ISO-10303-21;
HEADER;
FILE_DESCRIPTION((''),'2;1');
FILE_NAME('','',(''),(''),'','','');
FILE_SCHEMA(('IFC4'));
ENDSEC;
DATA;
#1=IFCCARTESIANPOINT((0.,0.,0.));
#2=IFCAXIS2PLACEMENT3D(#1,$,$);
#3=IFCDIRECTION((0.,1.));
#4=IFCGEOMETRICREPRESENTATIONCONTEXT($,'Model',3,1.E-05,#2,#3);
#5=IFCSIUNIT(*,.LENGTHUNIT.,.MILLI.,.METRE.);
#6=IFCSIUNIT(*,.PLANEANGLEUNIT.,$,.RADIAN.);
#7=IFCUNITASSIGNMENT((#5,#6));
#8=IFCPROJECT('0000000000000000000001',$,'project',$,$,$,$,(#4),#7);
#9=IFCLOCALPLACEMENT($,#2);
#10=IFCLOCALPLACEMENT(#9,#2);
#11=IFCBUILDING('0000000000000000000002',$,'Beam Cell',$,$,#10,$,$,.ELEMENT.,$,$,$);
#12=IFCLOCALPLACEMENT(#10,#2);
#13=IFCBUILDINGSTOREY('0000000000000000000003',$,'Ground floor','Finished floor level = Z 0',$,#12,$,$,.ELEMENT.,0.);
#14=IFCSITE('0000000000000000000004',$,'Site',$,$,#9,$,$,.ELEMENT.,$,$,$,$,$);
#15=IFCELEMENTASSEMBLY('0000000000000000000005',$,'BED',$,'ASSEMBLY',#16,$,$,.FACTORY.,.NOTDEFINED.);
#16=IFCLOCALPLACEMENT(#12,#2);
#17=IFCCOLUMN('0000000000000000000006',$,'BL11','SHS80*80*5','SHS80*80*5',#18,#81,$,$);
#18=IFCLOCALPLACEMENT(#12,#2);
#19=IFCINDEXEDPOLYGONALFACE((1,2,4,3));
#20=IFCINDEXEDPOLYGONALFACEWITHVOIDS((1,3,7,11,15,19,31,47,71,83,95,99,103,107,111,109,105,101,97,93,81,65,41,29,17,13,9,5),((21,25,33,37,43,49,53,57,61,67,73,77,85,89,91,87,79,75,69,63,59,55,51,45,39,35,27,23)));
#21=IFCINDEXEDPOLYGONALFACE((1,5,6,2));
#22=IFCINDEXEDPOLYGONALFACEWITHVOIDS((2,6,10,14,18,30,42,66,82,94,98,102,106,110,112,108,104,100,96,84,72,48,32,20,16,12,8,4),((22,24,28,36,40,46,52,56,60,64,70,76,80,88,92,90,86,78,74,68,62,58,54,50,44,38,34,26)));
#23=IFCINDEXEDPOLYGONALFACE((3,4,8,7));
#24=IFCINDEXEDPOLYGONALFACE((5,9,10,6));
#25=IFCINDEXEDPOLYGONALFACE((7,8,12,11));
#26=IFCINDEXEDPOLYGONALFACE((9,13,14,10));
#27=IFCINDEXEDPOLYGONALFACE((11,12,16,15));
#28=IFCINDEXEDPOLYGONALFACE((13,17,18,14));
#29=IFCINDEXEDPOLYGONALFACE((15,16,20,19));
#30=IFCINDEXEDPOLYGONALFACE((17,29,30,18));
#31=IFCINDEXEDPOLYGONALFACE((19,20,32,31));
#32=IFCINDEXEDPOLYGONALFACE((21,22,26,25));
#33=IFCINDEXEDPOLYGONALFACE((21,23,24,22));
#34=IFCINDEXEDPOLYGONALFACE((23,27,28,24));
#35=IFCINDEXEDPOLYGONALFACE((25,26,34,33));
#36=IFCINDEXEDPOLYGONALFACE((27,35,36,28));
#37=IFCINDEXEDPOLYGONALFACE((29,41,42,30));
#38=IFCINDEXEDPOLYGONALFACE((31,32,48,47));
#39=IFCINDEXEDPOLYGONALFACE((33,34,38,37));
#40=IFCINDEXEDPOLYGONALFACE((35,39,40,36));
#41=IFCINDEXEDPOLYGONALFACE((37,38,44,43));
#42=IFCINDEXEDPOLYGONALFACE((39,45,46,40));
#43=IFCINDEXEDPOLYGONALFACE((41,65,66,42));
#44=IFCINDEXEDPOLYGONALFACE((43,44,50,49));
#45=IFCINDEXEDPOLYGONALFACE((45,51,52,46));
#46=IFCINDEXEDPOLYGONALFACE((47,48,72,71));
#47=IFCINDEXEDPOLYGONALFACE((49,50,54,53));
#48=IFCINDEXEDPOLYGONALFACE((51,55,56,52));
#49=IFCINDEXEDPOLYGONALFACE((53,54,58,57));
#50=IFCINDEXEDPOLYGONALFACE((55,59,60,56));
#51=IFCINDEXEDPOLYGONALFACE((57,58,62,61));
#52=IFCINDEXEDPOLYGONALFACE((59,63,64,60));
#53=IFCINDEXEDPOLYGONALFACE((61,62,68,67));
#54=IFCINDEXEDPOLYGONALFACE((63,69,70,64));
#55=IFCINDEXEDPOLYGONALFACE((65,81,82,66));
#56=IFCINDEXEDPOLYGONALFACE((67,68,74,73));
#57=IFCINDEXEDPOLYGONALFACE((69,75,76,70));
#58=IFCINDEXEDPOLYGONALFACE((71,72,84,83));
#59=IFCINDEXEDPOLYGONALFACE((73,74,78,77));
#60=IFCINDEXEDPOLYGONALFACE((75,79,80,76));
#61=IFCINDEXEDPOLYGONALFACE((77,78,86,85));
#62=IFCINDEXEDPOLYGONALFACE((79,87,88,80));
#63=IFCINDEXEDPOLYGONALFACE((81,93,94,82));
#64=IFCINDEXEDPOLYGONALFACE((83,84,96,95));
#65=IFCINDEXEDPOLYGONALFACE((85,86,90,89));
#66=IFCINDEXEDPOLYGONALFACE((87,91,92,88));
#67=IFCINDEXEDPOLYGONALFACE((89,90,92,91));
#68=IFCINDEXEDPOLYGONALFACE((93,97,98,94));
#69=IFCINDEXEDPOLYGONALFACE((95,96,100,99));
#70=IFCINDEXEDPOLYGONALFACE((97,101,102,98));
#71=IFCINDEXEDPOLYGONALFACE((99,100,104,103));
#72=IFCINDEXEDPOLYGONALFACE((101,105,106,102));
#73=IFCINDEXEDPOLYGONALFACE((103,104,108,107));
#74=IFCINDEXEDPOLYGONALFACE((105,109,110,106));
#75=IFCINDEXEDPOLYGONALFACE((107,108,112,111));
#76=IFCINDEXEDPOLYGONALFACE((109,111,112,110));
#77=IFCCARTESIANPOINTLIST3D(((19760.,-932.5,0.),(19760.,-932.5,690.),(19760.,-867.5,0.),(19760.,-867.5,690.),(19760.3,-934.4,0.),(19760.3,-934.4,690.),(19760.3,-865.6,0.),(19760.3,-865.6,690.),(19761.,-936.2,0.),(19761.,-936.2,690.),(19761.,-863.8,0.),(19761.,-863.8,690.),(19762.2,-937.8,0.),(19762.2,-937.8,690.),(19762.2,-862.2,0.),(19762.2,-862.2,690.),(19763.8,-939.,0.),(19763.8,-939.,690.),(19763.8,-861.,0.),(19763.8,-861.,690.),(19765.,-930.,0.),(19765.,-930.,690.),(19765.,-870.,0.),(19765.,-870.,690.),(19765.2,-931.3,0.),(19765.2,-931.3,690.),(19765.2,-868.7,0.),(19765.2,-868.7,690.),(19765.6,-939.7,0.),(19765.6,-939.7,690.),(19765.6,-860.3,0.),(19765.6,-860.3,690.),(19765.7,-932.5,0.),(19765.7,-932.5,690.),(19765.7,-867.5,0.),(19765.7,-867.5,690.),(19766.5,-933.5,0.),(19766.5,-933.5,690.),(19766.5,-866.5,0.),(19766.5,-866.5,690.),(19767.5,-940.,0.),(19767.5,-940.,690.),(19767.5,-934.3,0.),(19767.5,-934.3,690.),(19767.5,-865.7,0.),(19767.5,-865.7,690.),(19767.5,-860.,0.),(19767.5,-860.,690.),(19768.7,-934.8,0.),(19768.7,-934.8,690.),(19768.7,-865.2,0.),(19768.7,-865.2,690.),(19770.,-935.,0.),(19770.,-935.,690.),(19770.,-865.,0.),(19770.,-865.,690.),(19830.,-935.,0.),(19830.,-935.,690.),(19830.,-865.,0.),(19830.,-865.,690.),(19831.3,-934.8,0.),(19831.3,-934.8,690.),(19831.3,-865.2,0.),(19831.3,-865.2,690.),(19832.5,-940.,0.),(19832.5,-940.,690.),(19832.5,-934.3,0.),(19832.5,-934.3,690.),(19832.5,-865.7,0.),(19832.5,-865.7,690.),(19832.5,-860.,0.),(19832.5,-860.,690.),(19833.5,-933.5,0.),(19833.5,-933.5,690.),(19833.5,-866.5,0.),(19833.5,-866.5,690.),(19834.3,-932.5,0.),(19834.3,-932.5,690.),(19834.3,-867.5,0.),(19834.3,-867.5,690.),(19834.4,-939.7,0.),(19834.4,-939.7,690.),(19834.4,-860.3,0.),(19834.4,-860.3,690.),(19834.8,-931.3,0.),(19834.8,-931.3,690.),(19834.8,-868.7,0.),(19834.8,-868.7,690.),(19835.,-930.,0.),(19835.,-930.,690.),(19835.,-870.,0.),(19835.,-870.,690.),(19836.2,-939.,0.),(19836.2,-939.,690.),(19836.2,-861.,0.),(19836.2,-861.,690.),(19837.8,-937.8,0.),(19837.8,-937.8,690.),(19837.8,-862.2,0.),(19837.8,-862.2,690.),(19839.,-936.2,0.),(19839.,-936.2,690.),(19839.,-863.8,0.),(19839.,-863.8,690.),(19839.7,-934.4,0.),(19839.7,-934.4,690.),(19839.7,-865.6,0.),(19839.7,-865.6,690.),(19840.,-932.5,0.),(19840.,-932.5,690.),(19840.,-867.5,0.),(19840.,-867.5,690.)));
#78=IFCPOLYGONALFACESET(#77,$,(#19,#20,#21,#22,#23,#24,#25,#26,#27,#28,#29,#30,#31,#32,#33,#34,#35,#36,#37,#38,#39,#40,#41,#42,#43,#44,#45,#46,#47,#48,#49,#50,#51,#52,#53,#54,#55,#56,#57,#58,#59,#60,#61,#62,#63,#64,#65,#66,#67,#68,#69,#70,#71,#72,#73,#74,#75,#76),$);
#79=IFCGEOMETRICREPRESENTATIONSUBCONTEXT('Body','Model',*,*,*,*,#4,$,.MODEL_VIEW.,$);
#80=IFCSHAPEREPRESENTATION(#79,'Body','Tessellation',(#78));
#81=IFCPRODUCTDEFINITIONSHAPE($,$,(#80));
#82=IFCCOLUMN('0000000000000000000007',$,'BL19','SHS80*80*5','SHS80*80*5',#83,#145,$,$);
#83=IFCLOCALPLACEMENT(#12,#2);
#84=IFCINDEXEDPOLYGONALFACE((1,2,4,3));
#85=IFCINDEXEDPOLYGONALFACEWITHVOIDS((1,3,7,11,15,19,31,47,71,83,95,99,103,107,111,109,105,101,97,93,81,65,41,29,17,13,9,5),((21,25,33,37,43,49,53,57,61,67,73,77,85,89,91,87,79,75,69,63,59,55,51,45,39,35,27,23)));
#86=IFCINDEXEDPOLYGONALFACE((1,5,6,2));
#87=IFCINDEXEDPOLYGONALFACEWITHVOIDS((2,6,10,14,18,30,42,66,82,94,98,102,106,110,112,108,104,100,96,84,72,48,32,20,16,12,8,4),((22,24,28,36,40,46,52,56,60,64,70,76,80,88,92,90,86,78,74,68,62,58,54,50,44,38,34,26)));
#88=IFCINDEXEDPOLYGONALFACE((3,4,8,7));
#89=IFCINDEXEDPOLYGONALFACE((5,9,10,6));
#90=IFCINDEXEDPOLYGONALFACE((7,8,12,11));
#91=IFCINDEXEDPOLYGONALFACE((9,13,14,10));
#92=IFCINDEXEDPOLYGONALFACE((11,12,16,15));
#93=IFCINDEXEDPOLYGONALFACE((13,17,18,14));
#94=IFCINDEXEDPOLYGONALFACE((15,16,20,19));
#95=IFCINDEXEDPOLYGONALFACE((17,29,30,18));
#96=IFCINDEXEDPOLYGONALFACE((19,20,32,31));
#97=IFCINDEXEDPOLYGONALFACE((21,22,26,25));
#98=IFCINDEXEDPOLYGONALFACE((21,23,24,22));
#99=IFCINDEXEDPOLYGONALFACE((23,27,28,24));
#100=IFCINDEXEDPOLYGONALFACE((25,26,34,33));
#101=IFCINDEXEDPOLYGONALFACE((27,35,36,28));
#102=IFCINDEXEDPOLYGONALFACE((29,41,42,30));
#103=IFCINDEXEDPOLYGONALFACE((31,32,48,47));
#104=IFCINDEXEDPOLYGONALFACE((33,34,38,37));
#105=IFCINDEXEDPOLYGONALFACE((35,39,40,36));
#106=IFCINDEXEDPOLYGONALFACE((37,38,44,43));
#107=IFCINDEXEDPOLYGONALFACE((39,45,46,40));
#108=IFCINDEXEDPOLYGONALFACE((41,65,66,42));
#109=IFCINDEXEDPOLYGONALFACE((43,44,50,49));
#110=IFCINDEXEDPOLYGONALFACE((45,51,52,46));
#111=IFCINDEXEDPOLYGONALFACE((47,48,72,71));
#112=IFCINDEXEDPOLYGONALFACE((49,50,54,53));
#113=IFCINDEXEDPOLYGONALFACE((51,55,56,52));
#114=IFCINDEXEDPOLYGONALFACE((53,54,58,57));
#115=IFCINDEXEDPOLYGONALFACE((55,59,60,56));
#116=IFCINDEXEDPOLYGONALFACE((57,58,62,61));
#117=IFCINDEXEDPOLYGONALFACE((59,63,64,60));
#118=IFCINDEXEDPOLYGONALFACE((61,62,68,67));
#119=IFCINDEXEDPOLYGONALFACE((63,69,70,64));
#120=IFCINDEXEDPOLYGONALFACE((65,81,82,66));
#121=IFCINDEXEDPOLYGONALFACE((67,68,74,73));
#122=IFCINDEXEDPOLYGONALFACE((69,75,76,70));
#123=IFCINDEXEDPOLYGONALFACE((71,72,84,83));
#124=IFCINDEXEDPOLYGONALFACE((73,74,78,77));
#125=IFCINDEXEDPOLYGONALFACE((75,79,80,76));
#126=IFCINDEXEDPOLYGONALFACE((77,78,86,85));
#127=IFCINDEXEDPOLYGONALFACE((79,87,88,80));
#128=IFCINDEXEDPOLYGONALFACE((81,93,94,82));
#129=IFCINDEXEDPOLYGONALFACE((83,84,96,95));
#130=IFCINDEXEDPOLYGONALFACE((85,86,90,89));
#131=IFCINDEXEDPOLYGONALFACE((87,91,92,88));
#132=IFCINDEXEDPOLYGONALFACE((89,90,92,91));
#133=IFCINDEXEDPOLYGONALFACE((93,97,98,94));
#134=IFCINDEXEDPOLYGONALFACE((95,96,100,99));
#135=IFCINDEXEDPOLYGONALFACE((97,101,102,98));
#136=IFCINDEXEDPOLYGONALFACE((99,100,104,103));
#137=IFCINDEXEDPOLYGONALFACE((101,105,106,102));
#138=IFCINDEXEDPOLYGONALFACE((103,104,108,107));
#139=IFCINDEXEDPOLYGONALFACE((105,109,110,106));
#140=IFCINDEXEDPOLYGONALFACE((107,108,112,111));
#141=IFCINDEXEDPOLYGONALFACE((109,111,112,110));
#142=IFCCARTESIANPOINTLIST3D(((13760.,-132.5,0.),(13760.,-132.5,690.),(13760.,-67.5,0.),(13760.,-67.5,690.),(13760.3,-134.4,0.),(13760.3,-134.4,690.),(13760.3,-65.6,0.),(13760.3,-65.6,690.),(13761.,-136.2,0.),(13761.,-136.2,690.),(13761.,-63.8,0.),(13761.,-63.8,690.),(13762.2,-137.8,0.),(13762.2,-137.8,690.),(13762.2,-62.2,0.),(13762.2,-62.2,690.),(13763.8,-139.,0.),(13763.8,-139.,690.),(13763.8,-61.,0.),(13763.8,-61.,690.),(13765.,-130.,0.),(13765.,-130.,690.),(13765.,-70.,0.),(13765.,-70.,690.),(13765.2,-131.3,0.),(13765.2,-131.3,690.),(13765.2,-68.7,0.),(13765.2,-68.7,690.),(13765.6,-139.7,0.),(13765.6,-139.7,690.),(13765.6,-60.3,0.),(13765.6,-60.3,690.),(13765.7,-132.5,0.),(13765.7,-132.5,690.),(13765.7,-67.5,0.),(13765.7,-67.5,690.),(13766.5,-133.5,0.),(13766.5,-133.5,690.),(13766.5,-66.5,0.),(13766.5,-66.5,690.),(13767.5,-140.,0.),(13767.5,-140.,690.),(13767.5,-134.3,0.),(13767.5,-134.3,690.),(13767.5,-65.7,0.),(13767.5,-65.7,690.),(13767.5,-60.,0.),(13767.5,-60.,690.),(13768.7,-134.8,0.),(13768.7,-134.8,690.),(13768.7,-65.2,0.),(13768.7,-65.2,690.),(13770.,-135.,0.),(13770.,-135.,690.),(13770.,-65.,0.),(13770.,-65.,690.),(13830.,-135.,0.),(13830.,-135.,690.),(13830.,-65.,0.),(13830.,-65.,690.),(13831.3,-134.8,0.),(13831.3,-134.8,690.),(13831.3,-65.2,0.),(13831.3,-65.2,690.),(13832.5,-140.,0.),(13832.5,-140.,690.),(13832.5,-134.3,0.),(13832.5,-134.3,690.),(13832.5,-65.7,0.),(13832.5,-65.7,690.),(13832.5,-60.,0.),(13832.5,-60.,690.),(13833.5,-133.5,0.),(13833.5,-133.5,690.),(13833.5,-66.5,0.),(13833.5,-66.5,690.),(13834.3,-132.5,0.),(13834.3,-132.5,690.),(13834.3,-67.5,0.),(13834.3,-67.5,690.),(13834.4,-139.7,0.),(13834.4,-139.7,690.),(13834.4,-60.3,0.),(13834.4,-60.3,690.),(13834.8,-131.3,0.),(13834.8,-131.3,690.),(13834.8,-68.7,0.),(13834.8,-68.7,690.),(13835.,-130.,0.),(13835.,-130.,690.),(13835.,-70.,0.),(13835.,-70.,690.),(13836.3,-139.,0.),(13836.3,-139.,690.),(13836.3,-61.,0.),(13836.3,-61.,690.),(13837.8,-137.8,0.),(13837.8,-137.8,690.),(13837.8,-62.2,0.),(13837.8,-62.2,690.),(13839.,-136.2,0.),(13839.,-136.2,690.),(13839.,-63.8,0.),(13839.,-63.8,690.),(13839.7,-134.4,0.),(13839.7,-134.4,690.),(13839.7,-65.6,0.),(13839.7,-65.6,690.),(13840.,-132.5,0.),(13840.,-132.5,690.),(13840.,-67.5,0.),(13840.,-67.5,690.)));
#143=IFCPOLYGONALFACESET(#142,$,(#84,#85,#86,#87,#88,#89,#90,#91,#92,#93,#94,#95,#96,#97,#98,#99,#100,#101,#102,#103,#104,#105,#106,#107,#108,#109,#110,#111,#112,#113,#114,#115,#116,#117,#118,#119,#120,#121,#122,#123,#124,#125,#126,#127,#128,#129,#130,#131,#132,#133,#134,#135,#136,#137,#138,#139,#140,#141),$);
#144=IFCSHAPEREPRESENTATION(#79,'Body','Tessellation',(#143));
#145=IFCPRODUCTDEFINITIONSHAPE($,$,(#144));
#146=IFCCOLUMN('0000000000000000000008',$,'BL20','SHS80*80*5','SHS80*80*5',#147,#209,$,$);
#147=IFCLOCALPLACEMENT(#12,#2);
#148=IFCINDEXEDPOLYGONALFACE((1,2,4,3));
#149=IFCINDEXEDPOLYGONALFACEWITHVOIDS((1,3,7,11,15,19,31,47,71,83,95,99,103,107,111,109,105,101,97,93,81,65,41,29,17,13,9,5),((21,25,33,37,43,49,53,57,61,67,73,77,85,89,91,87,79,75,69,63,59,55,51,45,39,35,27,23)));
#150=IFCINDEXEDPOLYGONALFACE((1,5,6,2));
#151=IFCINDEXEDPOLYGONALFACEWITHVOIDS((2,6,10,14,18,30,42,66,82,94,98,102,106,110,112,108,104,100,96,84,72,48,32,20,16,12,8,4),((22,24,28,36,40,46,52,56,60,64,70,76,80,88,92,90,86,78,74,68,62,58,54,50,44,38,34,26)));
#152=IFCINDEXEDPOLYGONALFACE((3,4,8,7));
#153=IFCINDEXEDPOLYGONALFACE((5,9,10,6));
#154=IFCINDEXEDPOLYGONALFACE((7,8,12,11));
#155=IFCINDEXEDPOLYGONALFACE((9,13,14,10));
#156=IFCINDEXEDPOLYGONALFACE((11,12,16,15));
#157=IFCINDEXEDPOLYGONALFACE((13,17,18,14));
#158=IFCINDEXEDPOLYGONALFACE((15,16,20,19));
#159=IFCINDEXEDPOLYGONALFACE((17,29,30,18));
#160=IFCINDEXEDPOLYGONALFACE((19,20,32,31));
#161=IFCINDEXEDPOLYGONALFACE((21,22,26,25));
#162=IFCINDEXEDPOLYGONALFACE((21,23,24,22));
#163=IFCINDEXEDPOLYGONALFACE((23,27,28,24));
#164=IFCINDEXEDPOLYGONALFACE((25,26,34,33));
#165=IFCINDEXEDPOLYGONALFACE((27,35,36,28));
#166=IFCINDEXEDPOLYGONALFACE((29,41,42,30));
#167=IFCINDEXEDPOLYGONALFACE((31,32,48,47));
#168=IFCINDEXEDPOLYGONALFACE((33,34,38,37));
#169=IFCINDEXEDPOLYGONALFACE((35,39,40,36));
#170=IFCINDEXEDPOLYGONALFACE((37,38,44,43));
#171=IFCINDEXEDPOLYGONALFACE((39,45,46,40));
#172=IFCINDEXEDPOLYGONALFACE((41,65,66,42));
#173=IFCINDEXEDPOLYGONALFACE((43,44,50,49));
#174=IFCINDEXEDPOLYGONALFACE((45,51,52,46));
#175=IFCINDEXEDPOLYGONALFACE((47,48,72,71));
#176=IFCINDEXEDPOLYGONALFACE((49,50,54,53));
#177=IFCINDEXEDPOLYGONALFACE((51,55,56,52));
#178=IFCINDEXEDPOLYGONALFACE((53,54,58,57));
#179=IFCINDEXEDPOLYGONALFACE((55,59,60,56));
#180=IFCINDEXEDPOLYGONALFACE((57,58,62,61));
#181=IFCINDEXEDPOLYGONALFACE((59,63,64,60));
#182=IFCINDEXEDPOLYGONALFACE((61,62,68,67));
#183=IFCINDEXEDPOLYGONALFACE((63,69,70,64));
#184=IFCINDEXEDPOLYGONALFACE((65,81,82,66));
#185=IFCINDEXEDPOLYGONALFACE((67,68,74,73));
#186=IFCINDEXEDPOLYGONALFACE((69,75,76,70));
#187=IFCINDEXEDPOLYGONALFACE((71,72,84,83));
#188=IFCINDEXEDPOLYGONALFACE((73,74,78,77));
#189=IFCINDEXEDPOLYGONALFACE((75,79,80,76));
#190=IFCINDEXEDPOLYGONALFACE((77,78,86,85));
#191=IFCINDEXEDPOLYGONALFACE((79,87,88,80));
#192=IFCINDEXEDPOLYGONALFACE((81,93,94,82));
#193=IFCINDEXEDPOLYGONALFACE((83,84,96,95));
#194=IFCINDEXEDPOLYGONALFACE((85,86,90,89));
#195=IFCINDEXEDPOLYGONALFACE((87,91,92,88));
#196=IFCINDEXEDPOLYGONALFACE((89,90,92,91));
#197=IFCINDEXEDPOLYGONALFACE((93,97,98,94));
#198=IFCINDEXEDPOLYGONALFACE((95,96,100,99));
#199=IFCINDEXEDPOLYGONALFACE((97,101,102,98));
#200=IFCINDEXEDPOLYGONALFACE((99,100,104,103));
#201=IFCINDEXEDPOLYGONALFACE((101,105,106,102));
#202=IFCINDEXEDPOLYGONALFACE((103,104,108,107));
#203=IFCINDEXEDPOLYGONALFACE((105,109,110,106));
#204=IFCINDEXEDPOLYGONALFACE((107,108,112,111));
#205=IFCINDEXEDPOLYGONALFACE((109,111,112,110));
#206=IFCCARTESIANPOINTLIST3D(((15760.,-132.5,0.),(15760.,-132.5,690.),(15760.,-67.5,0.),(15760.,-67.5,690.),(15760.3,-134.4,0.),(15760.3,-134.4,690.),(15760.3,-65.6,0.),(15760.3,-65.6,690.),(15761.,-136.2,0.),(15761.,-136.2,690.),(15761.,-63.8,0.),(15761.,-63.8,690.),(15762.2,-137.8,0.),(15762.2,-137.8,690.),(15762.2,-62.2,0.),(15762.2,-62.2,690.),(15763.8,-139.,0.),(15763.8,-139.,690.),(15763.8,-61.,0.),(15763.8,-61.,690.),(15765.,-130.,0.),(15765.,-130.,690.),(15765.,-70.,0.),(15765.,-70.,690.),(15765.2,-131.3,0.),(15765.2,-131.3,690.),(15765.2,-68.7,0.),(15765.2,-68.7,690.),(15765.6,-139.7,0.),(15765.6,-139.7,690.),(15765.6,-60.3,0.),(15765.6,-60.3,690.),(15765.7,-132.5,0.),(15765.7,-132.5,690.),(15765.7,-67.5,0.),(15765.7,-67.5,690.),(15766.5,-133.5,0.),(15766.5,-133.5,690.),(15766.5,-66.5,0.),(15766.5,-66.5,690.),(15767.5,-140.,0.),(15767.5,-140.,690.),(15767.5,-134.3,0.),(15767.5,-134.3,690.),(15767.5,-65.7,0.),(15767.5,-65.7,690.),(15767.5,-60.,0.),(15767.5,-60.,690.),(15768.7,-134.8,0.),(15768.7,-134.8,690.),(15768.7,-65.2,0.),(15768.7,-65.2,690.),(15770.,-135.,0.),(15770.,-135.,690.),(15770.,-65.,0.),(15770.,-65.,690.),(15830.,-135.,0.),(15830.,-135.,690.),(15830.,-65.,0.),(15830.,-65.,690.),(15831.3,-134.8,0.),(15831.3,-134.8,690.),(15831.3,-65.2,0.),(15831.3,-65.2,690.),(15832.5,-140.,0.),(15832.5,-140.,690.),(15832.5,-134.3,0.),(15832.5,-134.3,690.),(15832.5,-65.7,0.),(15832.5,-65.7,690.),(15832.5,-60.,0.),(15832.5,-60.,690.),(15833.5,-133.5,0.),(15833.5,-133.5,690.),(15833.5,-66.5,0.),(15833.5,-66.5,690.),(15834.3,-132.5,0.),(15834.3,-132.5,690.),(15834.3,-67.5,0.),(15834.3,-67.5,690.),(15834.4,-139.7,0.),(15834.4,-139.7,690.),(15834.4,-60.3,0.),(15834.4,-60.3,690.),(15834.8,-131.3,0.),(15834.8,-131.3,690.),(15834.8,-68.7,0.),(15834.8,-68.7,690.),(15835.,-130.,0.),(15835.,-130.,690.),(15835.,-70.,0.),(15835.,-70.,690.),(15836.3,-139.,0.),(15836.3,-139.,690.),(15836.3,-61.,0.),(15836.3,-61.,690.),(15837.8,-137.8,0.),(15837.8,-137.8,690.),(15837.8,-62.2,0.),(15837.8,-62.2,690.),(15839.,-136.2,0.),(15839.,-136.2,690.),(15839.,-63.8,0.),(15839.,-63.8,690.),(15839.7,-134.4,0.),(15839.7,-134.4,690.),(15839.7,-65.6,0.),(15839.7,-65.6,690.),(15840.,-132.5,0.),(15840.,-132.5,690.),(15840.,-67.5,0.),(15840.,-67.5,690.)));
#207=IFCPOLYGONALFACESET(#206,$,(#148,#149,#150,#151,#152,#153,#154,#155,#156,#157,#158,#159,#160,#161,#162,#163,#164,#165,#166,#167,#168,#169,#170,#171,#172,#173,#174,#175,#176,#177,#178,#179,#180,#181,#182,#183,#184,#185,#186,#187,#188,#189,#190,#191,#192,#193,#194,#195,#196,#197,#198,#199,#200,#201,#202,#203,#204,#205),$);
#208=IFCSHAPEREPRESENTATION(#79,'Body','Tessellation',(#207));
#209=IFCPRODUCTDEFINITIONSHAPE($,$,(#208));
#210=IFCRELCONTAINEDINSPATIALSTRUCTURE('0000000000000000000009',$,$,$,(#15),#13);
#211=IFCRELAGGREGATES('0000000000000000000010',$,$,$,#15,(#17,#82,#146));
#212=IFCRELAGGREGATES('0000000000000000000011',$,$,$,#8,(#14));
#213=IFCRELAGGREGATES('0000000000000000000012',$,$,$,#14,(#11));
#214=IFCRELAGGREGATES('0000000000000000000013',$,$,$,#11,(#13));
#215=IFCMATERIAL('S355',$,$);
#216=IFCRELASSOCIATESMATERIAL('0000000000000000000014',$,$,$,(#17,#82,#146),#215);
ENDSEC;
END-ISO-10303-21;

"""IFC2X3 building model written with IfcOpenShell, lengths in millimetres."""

from ifc_helpers import new_model, si_unit, direction, frame, origin, origin_2d, place, context, subcontext, project, spatial, hollow_rectangle, extrude, material, element, aggregate, save


model = new_model("IFC2X3")

# Units and contexts
model_context = context("Model", 3, precision=1e-05, world=origin(), true_north=direction((0.0, 1.0)))
body_context = subcontext(model_context, "Body", "Model", "MODEL_VIEW")
ifc_project = project(units=[si_unit("LENGTHUNIT", "METRE", prefix="MILLI"), si_unit("PLANEANGLEUNIT", "RADIAN")], contexts=[model_context])

# Site, building, storey
site_placement = place(None, origin())
site = spatial("IfcSite", under=ifc_project, at=site_placement, Name="Site", CompositionType="ELEMENT")
building_placement = place(site_placement, origin())
building = spatial("IfcBuilding", under=site, at=building_placement, Name="Beam Cell", CompositionType="ELEMENT")
storey_placement = place(building_placement, origin())
storey = spatial("IfcBuildingStorey", under=building, at=storey_placement, Name="Ground floor", Description="Finished floor level = Z 0", CompositionType="ELEMENT", Elevation=0.0)

# Element assembly, columns
ifc_material = material(Name="S355")
assembly_1_placement = place(storey_placement, origin())
assembly_1 = element("IfcElementAssembly", 1, at=assembly_1_placement, inside=storey, Name="BED", ObjectType="ASSEMBLY", AssemblyPlace="FACTORY", PredefinedType="NOTDEFINED")
column_1_placement = place(storey_placement, frame((19800.0, -900.0, 0.0), z_axis=(0.0, 0.0, 1.0), x_axis=(1.0, 0.0, 0.0)))
column_1 = element("IfcColumn", 2, at=column_1_placement, material=ifc_material, Name="BL11", Description="SHS80*80*5", ObjectType="SHS80*80*5", context=body_context, shape_type="SweptSolid", body=[
    extrude(hollow_rectangle(XDim=80.0, YDim=80.0, WallThickness=5.0, InnerFilletRadius=5.0, OuterFilletRadius=7.5, at=origin_2d()), origin(), (0.0, 0.0, 1.0), 690.0),
])
column_2_placement = place(storey_placement, frame((13800.0, -100.0, 0.0), z_axis=(0.0, 0.0, 1.0), x_axis=(1.0, 0.0, 0.0)))
column_2 = element("IfcColumn", 3, at=column_2_placement, material=ifc_material, Name="BL19", Description="SHS80*80*5", ObjectType="SHS80*80*5", context=body_context, shape_type="SweptSolid", body=[
    extrude(hollow_rectangle(XDim=80.0, YDim=80.0, WallThickness=5.0, InnerFilletRadius=5.0, OuterFilletRadius=7.5, at=origin_2d()), origin(), (0.0, 0.0, 1.0), 690.0),
])
column_3_placement = place(storey_placement, frame((15800.0, -100.0, 0.0), z_axis=(0.0, 0.0, 1.0), x_axis=(1.0, 0.0, 0.0)))
column_3 = element("IfcColumn", 4, at=column_3_placement, material=ifc_material, Name="BL20", Description="SHS80*80*5", ObjectType="SHS80*80*5", context=body_context, shape_type="SweptSolid", body=[
    extrude(hollow_rectangle(XDim=80.0, YDim=80.0, WallThickness=5.0, InnerFilletRadius=5.0, OuterFilletRadius=7.5, at=origin_2d()), origin(), (0.0, 0.0, 1.0), 690.0),
])
aggregate(assembly_1, [column_1, column_2, column_3])

save(model, "model.ifc")
